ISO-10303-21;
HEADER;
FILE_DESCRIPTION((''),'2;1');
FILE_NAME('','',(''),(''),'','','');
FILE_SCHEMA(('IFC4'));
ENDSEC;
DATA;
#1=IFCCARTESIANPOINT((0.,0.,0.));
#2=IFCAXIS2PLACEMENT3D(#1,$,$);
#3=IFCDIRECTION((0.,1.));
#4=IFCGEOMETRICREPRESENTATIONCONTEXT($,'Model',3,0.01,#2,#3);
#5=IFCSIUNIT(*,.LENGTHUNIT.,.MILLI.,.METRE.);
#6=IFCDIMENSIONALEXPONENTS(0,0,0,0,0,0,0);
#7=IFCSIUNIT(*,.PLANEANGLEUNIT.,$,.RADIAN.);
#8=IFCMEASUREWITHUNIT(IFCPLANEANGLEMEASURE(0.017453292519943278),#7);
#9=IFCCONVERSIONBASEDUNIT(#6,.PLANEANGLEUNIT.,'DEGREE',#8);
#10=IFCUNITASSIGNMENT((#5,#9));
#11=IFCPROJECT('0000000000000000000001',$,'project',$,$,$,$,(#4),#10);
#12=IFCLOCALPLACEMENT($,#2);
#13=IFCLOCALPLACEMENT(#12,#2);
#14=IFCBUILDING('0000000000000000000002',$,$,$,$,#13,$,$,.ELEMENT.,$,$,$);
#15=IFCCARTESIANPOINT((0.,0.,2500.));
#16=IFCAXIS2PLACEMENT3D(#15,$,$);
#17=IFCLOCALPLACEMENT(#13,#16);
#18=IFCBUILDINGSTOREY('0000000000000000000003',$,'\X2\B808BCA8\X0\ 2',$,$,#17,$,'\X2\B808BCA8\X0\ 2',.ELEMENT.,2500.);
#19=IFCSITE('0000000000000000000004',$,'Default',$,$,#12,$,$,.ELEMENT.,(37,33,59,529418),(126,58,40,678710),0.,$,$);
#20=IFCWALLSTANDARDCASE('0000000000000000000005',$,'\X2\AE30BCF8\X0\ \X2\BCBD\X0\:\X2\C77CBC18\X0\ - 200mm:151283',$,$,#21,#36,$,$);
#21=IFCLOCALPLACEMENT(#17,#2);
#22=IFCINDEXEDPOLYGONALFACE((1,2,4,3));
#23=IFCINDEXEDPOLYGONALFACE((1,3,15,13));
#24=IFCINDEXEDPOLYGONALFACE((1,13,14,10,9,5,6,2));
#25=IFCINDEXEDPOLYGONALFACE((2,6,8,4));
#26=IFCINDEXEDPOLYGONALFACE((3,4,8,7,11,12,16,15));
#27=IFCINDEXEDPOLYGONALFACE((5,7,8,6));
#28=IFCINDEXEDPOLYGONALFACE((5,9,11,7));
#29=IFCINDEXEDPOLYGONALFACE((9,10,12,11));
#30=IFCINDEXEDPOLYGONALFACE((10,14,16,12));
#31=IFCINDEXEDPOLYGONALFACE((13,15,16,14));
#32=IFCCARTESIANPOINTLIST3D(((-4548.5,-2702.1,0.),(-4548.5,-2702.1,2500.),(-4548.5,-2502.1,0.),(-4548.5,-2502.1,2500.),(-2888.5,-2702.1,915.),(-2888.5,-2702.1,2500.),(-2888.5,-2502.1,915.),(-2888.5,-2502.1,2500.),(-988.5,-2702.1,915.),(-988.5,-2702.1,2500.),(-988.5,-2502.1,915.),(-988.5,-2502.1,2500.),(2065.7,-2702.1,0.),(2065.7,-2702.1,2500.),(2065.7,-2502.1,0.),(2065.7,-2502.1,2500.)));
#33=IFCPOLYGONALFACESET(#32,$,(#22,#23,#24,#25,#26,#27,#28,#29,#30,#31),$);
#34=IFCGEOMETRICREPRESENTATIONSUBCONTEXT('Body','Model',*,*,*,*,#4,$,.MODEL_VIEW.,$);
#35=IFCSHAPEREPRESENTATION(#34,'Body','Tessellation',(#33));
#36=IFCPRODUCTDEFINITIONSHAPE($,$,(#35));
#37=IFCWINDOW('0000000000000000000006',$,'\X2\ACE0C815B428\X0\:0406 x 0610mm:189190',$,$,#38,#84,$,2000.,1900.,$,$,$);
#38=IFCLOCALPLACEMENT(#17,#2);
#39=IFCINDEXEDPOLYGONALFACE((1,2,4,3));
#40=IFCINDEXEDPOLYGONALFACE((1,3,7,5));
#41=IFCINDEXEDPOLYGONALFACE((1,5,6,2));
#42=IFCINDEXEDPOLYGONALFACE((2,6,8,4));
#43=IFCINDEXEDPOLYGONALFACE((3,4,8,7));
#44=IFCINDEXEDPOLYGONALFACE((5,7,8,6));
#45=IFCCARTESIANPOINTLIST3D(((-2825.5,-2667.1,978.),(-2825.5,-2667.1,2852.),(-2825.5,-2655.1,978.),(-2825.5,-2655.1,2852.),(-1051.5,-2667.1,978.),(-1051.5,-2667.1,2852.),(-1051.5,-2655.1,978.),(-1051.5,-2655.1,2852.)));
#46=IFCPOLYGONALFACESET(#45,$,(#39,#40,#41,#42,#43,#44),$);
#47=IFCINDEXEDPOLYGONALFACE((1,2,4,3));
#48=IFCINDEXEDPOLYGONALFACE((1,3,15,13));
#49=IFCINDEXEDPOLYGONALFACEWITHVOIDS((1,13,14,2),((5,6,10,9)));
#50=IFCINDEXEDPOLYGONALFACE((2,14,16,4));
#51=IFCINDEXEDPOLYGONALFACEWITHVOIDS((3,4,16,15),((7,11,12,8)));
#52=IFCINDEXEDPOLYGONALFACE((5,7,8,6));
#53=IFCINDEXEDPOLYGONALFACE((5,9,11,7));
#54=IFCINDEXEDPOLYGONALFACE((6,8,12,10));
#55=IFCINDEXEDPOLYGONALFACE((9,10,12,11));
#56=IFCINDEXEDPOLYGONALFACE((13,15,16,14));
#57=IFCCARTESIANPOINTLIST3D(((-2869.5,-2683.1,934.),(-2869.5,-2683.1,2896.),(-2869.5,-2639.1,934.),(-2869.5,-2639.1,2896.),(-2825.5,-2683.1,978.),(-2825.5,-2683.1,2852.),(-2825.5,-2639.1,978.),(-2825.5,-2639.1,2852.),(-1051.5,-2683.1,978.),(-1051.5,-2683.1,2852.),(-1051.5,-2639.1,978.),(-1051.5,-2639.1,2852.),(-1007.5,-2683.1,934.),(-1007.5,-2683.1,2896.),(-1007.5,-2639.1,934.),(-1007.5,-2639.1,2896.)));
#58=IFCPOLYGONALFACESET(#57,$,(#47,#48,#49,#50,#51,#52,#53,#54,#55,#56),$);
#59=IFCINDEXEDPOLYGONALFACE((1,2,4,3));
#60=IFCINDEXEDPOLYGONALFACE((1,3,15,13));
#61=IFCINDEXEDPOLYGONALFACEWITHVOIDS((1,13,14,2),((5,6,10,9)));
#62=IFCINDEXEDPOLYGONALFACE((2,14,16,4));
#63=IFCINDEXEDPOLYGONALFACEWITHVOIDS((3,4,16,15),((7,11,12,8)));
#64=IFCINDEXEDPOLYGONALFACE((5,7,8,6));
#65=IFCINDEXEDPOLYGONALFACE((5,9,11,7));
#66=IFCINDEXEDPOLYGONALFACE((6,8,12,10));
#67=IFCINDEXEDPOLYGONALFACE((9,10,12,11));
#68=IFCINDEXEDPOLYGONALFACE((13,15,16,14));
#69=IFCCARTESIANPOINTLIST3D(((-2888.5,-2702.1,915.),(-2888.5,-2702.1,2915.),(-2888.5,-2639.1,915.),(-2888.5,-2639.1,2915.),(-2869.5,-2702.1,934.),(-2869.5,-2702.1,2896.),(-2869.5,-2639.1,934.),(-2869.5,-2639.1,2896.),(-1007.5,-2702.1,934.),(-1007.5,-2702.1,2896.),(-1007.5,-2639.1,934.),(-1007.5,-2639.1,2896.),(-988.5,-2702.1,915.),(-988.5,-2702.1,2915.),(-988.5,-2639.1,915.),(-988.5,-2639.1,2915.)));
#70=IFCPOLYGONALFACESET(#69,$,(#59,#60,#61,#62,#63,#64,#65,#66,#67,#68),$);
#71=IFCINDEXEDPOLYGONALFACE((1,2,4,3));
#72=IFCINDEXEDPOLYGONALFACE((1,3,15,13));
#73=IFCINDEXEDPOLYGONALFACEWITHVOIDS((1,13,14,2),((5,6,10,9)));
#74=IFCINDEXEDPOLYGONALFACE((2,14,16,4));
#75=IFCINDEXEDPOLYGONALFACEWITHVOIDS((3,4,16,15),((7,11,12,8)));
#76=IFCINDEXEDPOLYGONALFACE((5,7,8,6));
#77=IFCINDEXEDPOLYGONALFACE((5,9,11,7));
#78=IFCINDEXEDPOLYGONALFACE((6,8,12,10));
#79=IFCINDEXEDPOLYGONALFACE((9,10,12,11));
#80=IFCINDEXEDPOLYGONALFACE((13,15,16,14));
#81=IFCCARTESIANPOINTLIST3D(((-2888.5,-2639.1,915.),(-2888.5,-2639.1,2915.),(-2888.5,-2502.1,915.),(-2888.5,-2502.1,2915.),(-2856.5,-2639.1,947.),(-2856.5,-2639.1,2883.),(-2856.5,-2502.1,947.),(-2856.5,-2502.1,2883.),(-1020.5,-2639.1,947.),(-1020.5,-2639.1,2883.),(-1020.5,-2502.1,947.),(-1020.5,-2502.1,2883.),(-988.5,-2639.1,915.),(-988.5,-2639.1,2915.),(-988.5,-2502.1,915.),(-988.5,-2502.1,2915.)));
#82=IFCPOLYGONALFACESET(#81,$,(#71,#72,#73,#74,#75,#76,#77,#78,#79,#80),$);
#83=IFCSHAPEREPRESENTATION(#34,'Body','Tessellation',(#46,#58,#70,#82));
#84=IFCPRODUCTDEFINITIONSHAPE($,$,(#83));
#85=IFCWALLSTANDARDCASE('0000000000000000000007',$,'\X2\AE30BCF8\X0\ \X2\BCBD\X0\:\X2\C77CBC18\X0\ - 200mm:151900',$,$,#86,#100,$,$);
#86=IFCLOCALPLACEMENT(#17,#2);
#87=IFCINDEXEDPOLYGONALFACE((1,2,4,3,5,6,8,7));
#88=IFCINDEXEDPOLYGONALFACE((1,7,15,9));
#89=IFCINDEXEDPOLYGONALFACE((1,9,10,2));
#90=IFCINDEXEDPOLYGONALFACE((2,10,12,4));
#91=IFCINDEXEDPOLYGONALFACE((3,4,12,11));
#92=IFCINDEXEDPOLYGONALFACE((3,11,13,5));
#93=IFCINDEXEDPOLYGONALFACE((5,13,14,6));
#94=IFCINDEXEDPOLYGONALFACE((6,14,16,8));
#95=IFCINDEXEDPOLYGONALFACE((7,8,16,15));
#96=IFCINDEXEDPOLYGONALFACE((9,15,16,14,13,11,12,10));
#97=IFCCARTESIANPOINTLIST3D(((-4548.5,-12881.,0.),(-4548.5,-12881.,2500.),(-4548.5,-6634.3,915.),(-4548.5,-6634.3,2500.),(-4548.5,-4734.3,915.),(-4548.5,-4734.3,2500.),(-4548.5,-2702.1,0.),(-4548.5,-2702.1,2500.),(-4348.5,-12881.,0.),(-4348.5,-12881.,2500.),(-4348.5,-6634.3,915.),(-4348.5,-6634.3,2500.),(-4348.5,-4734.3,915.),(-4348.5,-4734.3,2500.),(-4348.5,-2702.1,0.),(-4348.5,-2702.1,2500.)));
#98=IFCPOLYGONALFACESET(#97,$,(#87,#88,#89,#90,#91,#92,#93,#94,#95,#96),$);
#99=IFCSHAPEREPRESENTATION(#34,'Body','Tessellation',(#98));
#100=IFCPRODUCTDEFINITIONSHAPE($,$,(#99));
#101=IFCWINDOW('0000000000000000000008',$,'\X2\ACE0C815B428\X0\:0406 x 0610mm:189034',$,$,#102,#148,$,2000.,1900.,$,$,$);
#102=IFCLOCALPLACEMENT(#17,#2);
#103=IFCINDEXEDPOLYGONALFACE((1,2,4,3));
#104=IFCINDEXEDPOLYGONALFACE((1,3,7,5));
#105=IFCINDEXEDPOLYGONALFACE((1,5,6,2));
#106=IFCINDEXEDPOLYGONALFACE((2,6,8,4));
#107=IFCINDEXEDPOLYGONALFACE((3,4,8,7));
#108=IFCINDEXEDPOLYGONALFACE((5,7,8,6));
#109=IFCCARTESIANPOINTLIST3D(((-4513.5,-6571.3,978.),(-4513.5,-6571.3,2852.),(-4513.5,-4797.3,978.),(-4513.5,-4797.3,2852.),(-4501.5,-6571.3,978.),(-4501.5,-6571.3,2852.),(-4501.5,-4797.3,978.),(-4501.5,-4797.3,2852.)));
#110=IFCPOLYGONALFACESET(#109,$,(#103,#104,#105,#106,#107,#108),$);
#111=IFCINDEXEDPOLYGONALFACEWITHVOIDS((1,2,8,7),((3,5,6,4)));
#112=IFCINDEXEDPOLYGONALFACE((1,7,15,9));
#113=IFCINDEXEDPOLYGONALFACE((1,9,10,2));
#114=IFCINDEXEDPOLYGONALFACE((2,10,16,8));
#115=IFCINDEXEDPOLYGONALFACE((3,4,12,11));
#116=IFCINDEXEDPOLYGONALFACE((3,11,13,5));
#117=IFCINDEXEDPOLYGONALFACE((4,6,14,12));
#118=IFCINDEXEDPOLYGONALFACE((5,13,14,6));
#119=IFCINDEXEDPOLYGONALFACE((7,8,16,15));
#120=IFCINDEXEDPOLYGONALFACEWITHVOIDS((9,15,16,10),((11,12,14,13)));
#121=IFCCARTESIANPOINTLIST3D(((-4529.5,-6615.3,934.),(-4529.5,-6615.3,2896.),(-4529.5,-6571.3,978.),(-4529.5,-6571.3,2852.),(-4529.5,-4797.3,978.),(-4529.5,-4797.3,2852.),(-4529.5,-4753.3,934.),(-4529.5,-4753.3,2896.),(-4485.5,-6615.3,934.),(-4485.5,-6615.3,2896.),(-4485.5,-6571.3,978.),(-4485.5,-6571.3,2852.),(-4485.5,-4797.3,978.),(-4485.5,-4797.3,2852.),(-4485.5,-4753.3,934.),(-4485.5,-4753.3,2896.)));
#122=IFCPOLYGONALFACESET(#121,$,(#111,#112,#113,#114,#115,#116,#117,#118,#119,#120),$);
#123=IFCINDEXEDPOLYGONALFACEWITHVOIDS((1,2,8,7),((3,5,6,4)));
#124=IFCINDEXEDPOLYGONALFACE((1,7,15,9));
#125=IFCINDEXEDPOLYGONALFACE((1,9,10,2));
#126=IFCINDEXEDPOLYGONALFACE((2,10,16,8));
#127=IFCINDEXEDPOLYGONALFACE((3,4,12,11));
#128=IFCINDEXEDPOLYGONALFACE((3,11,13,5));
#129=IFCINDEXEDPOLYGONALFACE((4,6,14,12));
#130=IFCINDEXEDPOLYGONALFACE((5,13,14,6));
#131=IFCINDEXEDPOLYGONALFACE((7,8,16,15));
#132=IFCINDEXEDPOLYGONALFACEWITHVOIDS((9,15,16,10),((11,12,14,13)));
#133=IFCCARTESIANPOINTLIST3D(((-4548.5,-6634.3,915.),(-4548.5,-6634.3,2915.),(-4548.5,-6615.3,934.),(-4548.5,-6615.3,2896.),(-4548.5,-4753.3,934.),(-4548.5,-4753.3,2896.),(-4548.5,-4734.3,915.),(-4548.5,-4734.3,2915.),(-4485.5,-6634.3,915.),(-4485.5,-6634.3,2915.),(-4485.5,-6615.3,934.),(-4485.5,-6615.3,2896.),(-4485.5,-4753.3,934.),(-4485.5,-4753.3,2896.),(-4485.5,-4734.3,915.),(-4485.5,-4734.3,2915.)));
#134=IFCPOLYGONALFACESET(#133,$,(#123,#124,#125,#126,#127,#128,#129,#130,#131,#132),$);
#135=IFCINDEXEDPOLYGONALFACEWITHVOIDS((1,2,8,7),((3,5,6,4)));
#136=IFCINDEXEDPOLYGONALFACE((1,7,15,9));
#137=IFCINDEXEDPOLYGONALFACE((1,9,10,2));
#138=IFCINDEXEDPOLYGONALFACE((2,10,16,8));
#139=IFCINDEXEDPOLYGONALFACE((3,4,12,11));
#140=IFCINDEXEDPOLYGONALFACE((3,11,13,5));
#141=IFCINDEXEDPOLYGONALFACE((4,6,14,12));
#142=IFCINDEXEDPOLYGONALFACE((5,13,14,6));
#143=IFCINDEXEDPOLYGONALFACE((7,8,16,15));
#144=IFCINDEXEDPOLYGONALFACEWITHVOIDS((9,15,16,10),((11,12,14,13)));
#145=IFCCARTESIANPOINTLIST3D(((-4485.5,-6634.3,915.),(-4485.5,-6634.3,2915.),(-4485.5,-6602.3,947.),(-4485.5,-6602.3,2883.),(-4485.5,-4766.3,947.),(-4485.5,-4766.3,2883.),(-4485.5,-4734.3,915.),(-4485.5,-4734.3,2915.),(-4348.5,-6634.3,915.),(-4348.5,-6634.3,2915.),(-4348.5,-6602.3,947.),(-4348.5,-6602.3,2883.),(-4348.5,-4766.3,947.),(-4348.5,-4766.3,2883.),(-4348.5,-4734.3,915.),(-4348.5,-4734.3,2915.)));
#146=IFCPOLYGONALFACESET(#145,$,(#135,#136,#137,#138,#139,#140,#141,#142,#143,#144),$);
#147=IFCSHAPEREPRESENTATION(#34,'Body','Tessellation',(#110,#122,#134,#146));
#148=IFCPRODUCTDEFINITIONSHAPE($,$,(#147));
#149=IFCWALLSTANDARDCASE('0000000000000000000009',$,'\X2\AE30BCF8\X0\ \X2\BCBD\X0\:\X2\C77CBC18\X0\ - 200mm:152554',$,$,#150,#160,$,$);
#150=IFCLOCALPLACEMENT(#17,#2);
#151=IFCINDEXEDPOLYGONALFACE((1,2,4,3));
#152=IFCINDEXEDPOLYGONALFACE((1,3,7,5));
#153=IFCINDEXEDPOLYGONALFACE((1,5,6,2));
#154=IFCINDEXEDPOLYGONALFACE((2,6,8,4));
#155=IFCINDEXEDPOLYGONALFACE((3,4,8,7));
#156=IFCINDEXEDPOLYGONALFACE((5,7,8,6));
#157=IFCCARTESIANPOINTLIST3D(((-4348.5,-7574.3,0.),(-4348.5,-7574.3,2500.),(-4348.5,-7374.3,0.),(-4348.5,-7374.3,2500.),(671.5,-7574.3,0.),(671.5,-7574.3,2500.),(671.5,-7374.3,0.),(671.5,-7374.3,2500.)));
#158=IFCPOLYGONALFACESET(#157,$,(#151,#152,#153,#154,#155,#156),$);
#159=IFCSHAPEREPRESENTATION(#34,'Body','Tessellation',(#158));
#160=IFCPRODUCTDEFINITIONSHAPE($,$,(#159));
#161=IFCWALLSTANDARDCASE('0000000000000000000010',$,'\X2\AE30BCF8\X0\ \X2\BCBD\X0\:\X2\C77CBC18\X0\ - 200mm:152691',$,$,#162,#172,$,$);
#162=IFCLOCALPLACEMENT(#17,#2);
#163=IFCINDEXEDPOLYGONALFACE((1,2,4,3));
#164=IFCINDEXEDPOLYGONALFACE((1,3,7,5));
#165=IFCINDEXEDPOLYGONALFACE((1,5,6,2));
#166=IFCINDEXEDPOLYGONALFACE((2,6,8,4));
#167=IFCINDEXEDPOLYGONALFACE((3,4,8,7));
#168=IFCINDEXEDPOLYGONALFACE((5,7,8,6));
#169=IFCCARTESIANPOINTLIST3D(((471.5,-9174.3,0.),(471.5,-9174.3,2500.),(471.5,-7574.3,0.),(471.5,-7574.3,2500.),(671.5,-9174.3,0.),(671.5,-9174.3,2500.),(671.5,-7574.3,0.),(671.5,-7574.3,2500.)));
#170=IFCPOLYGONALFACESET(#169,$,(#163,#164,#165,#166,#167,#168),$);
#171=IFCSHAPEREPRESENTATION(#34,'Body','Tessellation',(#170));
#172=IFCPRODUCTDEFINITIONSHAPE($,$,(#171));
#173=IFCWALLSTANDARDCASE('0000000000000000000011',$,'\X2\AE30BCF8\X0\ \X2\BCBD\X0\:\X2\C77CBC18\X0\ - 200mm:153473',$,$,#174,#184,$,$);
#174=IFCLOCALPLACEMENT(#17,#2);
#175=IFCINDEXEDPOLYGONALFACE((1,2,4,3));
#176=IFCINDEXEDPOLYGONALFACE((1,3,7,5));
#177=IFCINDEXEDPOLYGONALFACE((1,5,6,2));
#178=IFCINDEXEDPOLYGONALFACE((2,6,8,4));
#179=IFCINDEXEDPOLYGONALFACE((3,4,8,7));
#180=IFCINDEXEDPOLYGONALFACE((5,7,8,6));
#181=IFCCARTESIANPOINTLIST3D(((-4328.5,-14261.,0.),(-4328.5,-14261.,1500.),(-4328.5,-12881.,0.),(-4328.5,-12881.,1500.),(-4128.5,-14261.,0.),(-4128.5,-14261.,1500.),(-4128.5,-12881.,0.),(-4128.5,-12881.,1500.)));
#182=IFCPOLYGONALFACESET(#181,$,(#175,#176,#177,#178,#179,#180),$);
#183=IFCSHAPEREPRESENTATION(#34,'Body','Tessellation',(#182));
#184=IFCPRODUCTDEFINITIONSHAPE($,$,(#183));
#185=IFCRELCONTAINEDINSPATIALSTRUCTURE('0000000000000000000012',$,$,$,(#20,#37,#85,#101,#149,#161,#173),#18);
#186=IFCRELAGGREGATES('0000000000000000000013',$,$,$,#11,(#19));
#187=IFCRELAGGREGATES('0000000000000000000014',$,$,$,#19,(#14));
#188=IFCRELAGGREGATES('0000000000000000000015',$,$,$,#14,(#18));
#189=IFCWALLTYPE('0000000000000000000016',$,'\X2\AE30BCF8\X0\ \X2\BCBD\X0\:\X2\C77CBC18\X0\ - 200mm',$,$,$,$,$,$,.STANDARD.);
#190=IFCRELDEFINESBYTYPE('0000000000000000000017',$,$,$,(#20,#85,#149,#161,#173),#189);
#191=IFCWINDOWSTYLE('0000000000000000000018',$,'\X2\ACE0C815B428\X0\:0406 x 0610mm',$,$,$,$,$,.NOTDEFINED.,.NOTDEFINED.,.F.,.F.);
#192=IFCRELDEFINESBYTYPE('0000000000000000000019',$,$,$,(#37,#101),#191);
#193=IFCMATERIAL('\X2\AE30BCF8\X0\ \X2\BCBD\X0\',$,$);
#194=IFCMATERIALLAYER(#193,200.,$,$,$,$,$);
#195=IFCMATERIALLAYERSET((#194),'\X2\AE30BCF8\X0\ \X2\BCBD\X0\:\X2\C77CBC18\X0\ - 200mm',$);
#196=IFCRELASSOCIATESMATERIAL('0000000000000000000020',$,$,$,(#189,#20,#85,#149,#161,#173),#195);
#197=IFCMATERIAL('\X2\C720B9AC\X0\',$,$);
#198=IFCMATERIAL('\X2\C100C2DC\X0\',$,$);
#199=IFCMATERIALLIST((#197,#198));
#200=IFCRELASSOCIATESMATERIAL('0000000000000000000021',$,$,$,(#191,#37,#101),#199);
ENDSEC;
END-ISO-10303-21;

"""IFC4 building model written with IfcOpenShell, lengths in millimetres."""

from ifc_helpers import new_model, entity, si_unit, converted_unit, direction, frame, frame_2d, origin, place, context, subcontext, project, spatial, polyline, rectangle, outline, extrude, source, transform, mapped, material, material_list, layer, layer_set, layer_usage, type_object, type_shapes, element, fill, save


model = new_model("IFC4")

# Units and contexts
model_context = context("Model", 3, precision=0.01, world=origin(), true_north=direction((0.0, 1.0)))
body_context = subcontext(model_context, "Body", "Model", "MODEL_VIEW")
ifc_project = project(units=[si_unit("LENGTHUNIT", "METRE", prefix="MILLI"), converted_unit("PLANEANGLEUNIT", "DEGREE", entity("IfcPlaneAngleMeasure", 0.017453292519943278), si_unit("PLANEANGLEUNIT", "RADIAN"), dimensions=[0, 0, 0, 0, 0, 0, 0])], contexts=[model_context])

# Site, building, storey
site_placement = place(None, origin())
site = spatial("IfcSite", under=ifc_project, at=site_placement, Name="Default", CompositionType="ELEMENT", RefLatitude=(37, 33, 59, 529418), RefLongitude=(126, 58, 40, 678710), RefElevation=0.0)
building_placement = place(site_placement, origin())
building = spatial("IfcBuilding", under=site, at=building_placement, CompositionType="ELEMENT")
storey_placement = place(building_placement, frame((0.0, 0.0, 2500.0)))
storey = spatial("IfcBuildingStorey", under=building, at=storey_placement, Name="레벨 2", LongName="레벨 2", CompositionType="ELEMENT", Elevation=2500.0)

# Shared definitions
ifc_material_1 = material(Name="기본 벽")
ifc_layer_1 = layer(ifc_material_1, 200.0)
ifc_layer_set_1 = layer_set([ifc_layer_1], Name="기본 벽:일반 - 200mm")
wall_type = type_object("IfcWallType", Name="기본 벽:일반 - 200mm", PredefinedType="STANDARD", material=ifc_layer_set_1)

# Shared definitions
ifc_material_2 = material(Name="유리")
ifc_material_3 = material(Name="섀시")
ifc_material_list_1 = material_list([ifc_material_2, ifc_material_3])
window_style = type_object("IfcWindowStyle", Name="고정됨:0406 x 0610mm", ConstructionType="NOTDEFINED", OperationType="NOTDEFINED", ParameterTakesPrecedence=False, Sizeable=False, material=ifc_material_list_1)
shared_shape_1 = source(origin(), body_context, "Body", "SweptSolid", [
    extrude(rectangle(XDim=12.0, YDim=1774.0, at=frame_2d((0.0, 0.0), x_axis=(1.0, 0.0))), frame((950.0, 159.0, 63.0), z_axis=(0.0, 0.0, 1.0), x_axis=(0.0, -1.0, 0.0)), (0.0, 0.0, 1.0), 1874.0),
    extrude(outline(polyline([(-931.0, -981.0), (931.0, -981.0), (931.0, 981.0), (-931.0, 981.0), (-931.0, -981.0)]), holes=[polyline([(-887.0, -937.0), (-887.0, 937.0), (887.0, 937.0), (887.0, -937.0), (-887.0, -937.0)])]), frame((950.0, 137.0, 1000.0), z_axis=(0.0, 1.0, 0.0), x_axis=(1.0, 0.0, 0.0)), (0.0, 0.0, 1.0), 44.0),
    extrude(outline(polyline([(-950.0, -1000.0), (950.0, -1000.0), (950.0, 1000.0), (-950.0, 1000.0), (-950.0, -1000.0)]), holes=[polyline([(-931.0, -981.0), (-931.0, 981.0), (931.0, 981.0), (931.0, -981.0), (-931.0, -981.0)])]), frame((950.0, 137.0, 1000.0), z_axis=(0.0, 1.0, 0.0), x_axis=(1.0, 0.0, 0.0)), (0.0, 0.0, 1.0), 63.0),
    extrude(outline(polyline([(-950.0, -1000.0), (950.0, -1000.0), (950.0, 1000.0), (-950.0, 1000.0), (-950.0, -1000.0)]), holes=[polyline([(-918.0, -968.0), (-918.0, 968.0), (918.0, 968.0), (918.0, -968.0), (-918.0, -968.0)])]), frame((950.0, 0.0, 1000.0), z_axis=(0.0, 1.0, 0.0), x_axis=(1.0, 0.0, 0.0)), (0.0, 0.0, 1.0), 137.0),
])
type_shapes(window_style, [shared_shape_1])

# Walls, openings, windows
ifc_layer_usage_1 = layer_usage(ifc_layer_set_1, "AXIS2", "NEGATIVE", 100.0)
wall_1_placement = place(storey_placement, frame((-4548.5, -2602.1, 0.0)))
wall_1 = element("IfcWallStandardCase", 1, at=wall_1_placement, inside=storey, type_object=wall_type, material=ifc_layer_usage_1, Name="기본 벽:일반 - 200mm:151283", context=body_context, shape_type="SweptSolid", body=[
    extrude(rectangle(XDim=6614.2, YDim=200.0, at=frame_2d((3307.1, 0.0), x_axis=(-1.0, 0.0))), origin(), (0.0, 0.0, 1.0), 2500.0),
])
opening_1_placement = place(wall_1_placement, frame((3560.0, 100.0, 915.0)))
opening_1 = element("IfcOpeningElement", 2, at=opening_1_placement, cuts=wall_1, ObjectType="Opening", context=body_context, shape_type="SweptSolid", body=[
    extrude(rectangle(XDim=2000.0, YDim=1900.0, at=frame_2d((1000.0, 950.0), x_axis=(1.0, 0.0))), frame((0.0, 0.0, 0.0), z_axis=(0.0, -1.0, 0.0), x_axis=(0.0, 0.0, 1.0)), (0.0, 0.0, 1.0), 200.0),
])
window_1_placement = place(opening_1_placement, frame((0.0, 0.0, 0.0), z_axis=(0.0, 0.0, 1.0), x_axis=(-1.0, 0.0, 0.0)))
window_1 = element("IfcWindow", 3, at=window_1_placement, inside=storey, type_object=window_style, material=ifc_material_list_1, Name="고정됨:0406 x 0610mm:189190", OverallHeight=2000.0, OverallWidth=1900.0, context=body_context, shape_type="MappedRepresentation", body=[
    mapped(shared_shape_1, transform((0.0, 0.0, 0.0), scale=1.0)),
])
fill(opening_1, window_1)
ifc_layer_usage_2 = layer_usage(ifc_layer_set_1, "AXIS2", "NEGATIVE", 100.0)
wall_2_placement = place(storey_placement, frame((-4448.5, -12881.0, 0.0), z_axis=(0.0, 0.0, 1.0), x_axis=(0.0, 1.0, 0.0)))
wall_2 = element("IfcWallStandardCase", 4, at=wall_2_placement, inside=storey, type_object=wall_type, material=ifc_layer_usage_2, Name="기본 벽:일반 - 200mm:151900", context=body_context, shape_type="SweptSolid", body=[
    extrude(rectangle(XDim=10178.9, YDim=200.0, at=frame_2d((5089.4, 0.0), x_axis=(-1.0, 0.0))), origin(), (0.0, 0.0, 1.0), 2500.0),
])
opening_2_placement = place(wall_2_placement, frame((6246.6, -100.0, 915.0)))
opening_2 = element("IfcOpeningElement", 5, at=opening_2_placement, cuts=wall_2, ObjectType="Opening", context=body_context, shape_type="SweptSolid", body=[
    extrude(rectangle(XDim=2000.0, YDim=1900.0, at=frame_2d((1000.0, 950.0), x_axis=(1.0, 0.0))), frame((0.0, 0.0, 0.0), z_axis=(0.0, 1.0, 0.0), x_axis=(0.0, 0.0, 1.0)), (0.0, 0.0, 1.0), 200.0),
])
window_2_placement = place(opening_2_placement, origin())
window_2 = element("IfcWindow", 6, at=window_2_placement, inside=storey, type_object=window_style, material=ifc_material_list_1, Name="고정됨:0406 x 0610mm:189034", OverallHeight=2000.0, OverallWidth=1900.0, context=body_context, shape_type="MappedRepresentation", body=[
    mapped(shared_shape_1, transform((0.0, 0.0, 0.0), scale=1.0)),
])
fill(opening_2, window_2)

# Walls
ifc_layer_usage_3 = layer_usage(ifc_layer_set_1, "AXIS2", "NEGATIVE", 100.0)
wall_3_placement = place(storey_placement, frame((-4348.5, -7474.3, 0.0)))
element("IfcWallStandardCase", 7, at=wall_3_placement, inside=storey, type_object=wall_type, material=ifc_layer_usage_3, Name="기본 벽:일반 - 200mm:152554", context=body_context, shape_type="SweptSolid", body=[
    extrude(rectangle(XDim=5020.0, YDim=200.0, at=frame_2d((2510.0, 0.0), x_axis=(-1.0, 0.0))), origin(), (0.0, 0.0, 1.0), 2500.0),
])
ifc_layer_usage_4 = layer_usage(ifc_layer_set_1, "AXIS2", "NEGATIVE", 100.0)
wall_4_placement = place(storey_placement, frame((571.5, -7574.3, 0.0), z_axis=(0.0, 0.0, 1.0), x_axis=(0.0, -1.0, 0.0)))
element("IfcWallStandardCase", 8, at=wall_4_placement, inside=storey, type_object=wall_type, material=ifc_layer_usage_4, Name="기본 벽:일반 - 200mm:152691", context=body_context, shape_type="SweptSolid", body=[
    extrude(rectangle(XDim=1600.0, YDim=200.0, at=frame_2d((800.0, 0.0), x_axis=(-1.0, 0.0))), origin(), (0.0, 0.0, 1.0), 2500.0),
])
ifc_layer_usage_5 = layer_usage(ifc_layer_set_1, "AXIS2", "NEGATIVE", 100.0)
wall_5_placement = place(storey_placement, frame((-4228.5, -12881.0, 0.0), z_axis=(0.0, 0.0, 1.0), x_axis=(0.0, -1.0, 0.0)))
element("IfcWallStandardCase", 9, at=wall_5_placement, inside=storey, type_object=wall_type, material=ifc_layer_usage_5, Name="기본 벽:일반 - 200mm:153473", context=body_context, shape_type="SweptSolid", body=[
    extrude(rectangle(XDim=1380.0, YDim=200.0, at=frame_2d((690.0, 0.0), x_axis=(-1.0, 0.0))), origin(), (0.0, 0.0, 1.0), 1500.0),
])

save(model, "model.ifc")
